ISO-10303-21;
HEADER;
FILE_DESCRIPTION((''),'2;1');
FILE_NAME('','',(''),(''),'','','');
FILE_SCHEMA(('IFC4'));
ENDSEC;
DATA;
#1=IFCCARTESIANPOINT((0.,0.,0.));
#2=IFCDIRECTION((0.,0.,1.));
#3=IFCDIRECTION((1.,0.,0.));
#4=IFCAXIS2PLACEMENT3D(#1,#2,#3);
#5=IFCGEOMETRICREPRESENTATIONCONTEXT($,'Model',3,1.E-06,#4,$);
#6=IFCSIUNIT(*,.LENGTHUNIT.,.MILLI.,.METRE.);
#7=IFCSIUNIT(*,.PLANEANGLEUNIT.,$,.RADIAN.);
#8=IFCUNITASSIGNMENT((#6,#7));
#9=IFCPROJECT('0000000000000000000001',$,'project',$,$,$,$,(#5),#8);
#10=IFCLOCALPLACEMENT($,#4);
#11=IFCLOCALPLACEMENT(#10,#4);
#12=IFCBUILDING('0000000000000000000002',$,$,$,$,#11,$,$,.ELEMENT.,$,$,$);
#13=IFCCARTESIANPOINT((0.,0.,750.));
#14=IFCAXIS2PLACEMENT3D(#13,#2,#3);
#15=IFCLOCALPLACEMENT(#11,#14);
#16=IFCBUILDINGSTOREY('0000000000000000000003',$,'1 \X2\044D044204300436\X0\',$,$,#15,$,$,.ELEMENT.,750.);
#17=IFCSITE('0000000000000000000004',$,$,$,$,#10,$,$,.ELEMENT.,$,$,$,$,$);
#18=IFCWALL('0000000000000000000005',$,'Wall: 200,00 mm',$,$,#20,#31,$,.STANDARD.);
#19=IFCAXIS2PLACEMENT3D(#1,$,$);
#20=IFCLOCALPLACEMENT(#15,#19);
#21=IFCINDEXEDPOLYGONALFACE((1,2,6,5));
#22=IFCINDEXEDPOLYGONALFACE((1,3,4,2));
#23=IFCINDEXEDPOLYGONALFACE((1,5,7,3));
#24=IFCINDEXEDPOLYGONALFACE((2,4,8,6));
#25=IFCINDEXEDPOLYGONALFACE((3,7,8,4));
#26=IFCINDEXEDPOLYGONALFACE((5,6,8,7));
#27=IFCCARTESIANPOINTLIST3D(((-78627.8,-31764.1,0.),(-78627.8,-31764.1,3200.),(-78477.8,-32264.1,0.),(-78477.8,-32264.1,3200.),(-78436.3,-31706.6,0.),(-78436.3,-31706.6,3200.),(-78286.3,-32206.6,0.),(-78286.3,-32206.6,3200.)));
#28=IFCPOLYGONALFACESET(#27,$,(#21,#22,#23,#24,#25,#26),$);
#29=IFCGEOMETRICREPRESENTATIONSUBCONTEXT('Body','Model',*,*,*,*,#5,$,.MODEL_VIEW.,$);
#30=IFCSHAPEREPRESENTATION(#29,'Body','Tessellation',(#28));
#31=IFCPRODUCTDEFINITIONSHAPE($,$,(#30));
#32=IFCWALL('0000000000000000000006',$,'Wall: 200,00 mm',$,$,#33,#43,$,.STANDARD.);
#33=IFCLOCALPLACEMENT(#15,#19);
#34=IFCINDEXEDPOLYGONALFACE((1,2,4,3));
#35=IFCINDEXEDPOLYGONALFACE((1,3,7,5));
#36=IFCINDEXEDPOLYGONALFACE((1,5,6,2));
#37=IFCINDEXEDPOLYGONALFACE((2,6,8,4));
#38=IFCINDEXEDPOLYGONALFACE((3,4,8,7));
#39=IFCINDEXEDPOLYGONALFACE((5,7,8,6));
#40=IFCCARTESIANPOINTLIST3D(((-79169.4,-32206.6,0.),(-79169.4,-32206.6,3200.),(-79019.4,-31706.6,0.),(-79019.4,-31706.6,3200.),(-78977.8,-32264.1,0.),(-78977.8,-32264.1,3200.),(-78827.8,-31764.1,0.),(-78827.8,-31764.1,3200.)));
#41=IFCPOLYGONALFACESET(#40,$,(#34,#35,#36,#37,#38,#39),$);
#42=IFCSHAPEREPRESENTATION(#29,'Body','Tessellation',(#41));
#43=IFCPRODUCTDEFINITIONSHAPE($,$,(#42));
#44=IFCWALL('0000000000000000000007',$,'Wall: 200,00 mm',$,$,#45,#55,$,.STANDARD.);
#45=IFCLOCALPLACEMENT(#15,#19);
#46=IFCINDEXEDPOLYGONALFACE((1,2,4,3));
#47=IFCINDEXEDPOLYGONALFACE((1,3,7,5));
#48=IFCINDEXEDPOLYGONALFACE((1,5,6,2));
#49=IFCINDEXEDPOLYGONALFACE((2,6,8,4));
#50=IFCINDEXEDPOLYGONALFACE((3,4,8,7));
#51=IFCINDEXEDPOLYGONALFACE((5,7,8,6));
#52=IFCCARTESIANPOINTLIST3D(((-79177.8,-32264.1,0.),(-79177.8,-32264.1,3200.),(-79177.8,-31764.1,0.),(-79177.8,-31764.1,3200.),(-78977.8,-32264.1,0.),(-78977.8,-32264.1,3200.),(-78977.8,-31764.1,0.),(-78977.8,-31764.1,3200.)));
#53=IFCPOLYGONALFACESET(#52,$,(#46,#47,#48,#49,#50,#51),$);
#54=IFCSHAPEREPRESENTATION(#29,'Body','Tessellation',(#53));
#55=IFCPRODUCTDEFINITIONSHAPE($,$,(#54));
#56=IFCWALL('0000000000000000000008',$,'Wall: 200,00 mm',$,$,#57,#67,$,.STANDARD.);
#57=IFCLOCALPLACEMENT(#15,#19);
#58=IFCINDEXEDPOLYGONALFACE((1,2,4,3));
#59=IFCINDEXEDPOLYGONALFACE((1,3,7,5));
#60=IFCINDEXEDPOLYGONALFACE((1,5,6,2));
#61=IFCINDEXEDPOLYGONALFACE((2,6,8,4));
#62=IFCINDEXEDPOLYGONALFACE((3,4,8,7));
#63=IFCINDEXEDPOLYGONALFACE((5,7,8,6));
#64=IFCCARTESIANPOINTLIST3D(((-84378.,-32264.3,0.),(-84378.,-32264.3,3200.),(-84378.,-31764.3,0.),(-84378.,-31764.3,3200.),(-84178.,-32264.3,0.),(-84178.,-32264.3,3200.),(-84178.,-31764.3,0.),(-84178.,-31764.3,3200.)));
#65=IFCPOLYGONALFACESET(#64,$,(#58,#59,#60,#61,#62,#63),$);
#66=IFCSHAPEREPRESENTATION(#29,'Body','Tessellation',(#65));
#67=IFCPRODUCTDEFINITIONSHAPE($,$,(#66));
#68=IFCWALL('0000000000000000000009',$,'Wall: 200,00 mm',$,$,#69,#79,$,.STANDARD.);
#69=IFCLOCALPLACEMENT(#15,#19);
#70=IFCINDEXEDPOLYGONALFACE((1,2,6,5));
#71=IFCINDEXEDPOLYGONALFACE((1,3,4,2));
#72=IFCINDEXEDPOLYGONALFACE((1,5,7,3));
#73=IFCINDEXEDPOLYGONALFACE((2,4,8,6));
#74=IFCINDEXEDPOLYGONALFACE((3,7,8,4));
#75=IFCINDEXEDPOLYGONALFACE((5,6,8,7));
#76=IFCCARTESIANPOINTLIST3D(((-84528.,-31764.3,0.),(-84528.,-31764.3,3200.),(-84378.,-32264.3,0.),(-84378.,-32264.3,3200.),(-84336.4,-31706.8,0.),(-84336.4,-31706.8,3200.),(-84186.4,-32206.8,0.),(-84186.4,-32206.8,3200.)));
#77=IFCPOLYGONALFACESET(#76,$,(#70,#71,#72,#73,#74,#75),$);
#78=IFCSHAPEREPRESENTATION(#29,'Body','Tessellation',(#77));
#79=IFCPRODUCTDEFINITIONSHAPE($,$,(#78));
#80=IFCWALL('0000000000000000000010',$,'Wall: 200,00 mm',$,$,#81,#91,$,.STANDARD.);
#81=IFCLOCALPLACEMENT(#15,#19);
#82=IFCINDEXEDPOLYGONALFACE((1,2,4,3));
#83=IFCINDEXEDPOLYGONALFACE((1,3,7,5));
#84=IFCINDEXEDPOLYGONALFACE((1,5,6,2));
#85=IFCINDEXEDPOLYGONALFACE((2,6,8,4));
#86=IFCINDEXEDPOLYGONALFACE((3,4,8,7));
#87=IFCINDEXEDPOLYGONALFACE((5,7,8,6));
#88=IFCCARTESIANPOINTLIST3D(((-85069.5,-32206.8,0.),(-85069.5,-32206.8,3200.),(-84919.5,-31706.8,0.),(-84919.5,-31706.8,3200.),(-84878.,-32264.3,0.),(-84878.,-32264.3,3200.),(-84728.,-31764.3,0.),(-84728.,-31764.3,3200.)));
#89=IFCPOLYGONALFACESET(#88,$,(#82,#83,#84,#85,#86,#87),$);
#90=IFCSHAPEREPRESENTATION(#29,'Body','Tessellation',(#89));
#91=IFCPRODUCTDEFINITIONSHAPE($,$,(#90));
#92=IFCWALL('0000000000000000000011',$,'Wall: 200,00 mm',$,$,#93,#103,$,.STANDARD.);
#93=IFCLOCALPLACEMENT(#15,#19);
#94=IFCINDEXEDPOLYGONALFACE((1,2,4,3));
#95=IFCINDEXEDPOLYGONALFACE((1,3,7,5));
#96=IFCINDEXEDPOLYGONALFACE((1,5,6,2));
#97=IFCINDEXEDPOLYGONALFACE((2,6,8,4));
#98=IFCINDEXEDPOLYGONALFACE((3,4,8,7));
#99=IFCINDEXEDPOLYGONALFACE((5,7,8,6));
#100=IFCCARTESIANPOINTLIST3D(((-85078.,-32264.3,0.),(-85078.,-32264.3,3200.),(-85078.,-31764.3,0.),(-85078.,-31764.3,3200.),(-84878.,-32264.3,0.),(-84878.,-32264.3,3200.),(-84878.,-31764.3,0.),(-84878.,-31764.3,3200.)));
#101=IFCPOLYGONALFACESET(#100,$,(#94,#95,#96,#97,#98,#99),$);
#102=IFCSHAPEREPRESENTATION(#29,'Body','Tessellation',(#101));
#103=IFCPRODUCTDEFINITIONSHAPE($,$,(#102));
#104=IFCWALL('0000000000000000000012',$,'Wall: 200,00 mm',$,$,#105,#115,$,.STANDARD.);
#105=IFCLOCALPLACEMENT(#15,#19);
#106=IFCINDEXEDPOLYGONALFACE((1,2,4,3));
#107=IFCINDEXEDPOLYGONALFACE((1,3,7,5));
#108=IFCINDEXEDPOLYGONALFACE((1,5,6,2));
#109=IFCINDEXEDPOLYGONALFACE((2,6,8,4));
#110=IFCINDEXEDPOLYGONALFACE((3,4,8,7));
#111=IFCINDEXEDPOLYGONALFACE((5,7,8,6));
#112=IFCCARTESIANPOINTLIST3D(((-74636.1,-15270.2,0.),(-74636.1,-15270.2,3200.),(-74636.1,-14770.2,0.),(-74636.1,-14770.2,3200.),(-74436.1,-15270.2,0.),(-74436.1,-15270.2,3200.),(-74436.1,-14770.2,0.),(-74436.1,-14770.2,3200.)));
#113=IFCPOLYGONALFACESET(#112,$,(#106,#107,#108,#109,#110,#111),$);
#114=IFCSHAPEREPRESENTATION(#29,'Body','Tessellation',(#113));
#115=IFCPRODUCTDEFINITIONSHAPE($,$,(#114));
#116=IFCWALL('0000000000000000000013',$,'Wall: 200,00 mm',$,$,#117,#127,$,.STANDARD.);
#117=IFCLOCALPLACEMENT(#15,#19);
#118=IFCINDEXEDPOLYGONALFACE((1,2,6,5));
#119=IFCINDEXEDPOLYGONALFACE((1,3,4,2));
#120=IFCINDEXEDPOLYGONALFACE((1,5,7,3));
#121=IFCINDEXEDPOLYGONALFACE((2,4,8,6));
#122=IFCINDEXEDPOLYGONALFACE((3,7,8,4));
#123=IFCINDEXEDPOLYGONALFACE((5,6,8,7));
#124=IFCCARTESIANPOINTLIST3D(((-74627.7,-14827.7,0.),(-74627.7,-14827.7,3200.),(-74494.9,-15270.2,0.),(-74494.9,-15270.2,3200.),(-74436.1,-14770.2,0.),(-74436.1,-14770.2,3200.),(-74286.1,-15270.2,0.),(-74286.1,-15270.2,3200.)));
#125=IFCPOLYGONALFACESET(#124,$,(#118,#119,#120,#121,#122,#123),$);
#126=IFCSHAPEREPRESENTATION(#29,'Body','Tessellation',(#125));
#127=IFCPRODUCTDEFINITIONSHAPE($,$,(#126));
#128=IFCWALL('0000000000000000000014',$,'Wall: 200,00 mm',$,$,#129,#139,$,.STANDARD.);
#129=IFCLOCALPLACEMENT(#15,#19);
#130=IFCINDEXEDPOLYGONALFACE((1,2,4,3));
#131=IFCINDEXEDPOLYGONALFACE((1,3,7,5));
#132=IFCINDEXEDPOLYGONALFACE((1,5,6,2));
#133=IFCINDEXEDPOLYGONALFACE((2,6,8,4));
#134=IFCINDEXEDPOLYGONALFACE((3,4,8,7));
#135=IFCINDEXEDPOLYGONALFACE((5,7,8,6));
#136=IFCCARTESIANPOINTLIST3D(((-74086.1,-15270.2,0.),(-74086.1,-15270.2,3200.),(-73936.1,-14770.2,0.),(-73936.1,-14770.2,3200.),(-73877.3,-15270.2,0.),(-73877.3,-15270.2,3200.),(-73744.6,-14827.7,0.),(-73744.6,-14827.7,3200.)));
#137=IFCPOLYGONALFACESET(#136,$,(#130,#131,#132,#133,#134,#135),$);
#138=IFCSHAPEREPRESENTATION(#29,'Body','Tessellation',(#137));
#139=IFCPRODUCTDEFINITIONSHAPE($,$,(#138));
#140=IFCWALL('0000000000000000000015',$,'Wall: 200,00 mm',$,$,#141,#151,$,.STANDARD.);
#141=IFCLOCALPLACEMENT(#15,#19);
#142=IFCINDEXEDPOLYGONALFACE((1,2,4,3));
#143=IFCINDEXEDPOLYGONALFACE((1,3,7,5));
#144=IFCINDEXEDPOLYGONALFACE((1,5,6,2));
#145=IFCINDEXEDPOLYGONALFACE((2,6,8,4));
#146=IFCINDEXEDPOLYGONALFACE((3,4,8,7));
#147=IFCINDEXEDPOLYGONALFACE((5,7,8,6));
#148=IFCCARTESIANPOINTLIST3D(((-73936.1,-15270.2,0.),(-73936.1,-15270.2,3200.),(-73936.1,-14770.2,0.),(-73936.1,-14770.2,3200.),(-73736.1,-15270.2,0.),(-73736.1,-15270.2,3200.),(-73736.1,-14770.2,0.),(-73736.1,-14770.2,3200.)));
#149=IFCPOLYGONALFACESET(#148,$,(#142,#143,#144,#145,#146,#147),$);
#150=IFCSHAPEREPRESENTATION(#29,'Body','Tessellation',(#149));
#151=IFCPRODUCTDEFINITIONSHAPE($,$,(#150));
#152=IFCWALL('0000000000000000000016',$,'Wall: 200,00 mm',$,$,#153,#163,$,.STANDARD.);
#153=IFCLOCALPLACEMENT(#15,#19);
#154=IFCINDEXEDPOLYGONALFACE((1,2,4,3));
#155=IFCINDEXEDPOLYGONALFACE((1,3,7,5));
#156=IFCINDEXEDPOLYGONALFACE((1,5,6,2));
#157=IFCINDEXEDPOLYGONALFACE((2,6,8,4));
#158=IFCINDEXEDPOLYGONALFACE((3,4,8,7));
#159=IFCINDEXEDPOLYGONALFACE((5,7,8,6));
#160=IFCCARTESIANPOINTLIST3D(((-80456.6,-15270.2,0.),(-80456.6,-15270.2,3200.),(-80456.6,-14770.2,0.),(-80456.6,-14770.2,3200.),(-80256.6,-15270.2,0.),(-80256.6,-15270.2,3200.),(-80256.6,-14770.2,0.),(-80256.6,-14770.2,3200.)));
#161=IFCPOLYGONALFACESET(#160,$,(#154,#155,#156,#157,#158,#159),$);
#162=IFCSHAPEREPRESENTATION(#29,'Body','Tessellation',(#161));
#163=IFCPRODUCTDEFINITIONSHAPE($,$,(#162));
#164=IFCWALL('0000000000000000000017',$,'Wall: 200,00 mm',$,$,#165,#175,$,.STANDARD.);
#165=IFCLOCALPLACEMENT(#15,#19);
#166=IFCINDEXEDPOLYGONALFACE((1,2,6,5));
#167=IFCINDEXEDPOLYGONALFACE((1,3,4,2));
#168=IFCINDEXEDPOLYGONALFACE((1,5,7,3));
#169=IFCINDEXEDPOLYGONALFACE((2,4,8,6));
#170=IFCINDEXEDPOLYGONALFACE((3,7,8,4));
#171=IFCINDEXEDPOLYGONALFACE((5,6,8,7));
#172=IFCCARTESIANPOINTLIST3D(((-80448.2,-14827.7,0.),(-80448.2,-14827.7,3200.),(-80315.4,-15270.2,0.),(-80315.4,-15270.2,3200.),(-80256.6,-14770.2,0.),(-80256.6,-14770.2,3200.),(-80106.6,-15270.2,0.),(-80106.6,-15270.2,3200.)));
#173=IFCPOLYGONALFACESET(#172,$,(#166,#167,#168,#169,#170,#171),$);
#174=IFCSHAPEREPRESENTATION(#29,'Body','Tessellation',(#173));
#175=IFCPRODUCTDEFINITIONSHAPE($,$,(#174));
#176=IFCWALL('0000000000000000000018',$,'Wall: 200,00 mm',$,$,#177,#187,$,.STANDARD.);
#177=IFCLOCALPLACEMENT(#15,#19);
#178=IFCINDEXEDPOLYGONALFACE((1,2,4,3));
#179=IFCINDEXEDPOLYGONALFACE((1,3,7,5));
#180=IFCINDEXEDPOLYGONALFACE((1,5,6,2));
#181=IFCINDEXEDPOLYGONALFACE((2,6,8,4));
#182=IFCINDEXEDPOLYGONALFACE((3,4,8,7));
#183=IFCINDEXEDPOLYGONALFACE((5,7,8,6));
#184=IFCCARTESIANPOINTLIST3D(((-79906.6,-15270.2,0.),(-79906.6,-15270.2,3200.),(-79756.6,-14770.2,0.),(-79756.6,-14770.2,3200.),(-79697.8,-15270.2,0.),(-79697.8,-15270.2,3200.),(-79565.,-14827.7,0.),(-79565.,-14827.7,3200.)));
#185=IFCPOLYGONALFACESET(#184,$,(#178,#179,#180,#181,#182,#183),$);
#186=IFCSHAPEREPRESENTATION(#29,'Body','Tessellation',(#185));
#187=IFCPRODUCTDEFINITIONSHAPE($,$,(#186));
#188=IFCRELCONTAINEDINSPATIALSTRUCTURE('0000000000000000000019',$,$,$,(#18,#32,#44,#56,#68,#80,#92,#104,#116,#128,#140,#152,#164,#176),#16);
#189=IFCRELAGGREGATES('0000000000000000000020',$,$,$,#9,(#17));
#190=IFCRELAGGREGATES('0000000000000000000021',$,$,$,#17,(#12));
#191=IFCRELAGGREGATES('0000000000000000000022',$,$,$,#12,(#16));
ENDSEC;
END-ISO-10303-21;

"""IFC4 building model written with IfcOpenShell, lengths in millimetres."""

from ifc_helpers import new_model, si_unit, frame, origin_with_axes, place, context, subcontext, project, spatial, line, indexed_curve, outline, extrude, element, save


model = new_model("IFC4")

# Units and contexts
model_context = context("Model", 3, precision=1e-06, world=origin_with_axes())
body_context = subcontext(model_context, "Body", "Model", "MODEL_VIEW")
ifc_project = project(units=[si_unit("LENGTHUNIT", "METRE", prefix="MILLI"), si_unit("PLANEANGLEUNIT", "RADIAN")], contexts=[model_context])

# Site, building, storey
site_placement = place(None, origin_with_axes())
site = spatial("IfcSite", under=ifc_project, at=site_placement, CompositionType="ELEMENT")
building_placement = place(site_placement, origin_with_axes())
building = spatial("IfcBuilding", under=site, at=building_placement, CompositionType="ELEMENT")
storey_placement = place(building_placement, frame((0.0, 0.0, 750.0), z_axis=(0.0, 0.0, 1.0), x_axis=(1.0, 0.0, 0.0)))
storey = spatial("IfcBuildingStorey", under=building, at=storey_placement, Name="1 этаж", CompositionType="ELEMENT", Elevation=750.0)

# Walls
wall_1_placement = place(storey_placement, frame((-78477.8, -32264.1, 0.0), z_axis=(0.0, 0.0, 1.0), x_axis=(-0.287348, 0.957826, 0.0)))
element("IfcWall", 1, at=wall_1_placement, inside=storey, Name="Wall: 200,00 mm", PredefinedType="STANDARD", context=body_context, shape_type="SweptSolid", body=[
    extrude(outline(indexed_curve([(0.0, -200.0), (522.0, -200.0), (522.0, 0.0), (0.0, 0.0)], segments=[line(1, 2), line(2, 3), line(3, 4), line(4, 1)])), origin_with_axes(), (0.0, 0.0, 1.0), 3200.0),
])
wall_2_placement = place(storey_placement, frame((-78977.8, -32264.1, 0.0), z_axis=(0.0, 0.0, 1.0), x_axis=(0.287348, 0.957826, 0.0)))
element("IfcWall", 2, at=wall_2_placement, inside=storey, Name="Wall: 200,00 mm", PredefinedType="STANDARD", context=body_context, shape_type="SweptSolid", body=[
    extrude(outline(indexed_curve([(0.0, 0.0), (522.0, 0.0), (522.0, 200.0), (0.0, 200.0)], segments=[line(1, 2), line(2, 3), line(3, 4), line(4, 1)])), origin_with_axes(), (0.0, 0.0, 1.0), 3200.0),
])
wall_3_placement = place(storey_placement, frame((-79177.8, -32264.1, 0.0), z_axis=(0.0, 0.0, 1.0), x_axis=(0.0, 1.0, 0.0)))
element("IfcWall", 3, at=wall_3_placement, inside=storey, Name="Wall: 200,00 mm", PredefinedType="STANDARD", context=body_context, shape_type="SweptSolid", body=[
    extrude(outline(indexed_curve([(0.0, -200.0), (500.0, -200.0), (500.0, 0.0), (0.0, 0.0)], segments=[line(1, 2), line(2, 3), line(3, 4), line(4, 1)])), origin_with_axes(), (0.0, 0.0, 1.0), 3200.0),
])
wall_4_placement = place(storey_placement, frame((-84178.0, -32264.3, 0.0), z_axis=(0.0, 0.0, 1.0), x_axis=(0.0, 1.0, 0.0)))
element("IfcWall", 4, at=wall_4_placement, inside=storey, Name="Wall: 200,00 mm", PredefinedType="STANDARD", context=body_context, shape_type="SweptSolid", body=[
    extrude(outline(indexed_curve([(0.0, 0.0), (500.0, 0.0), (500.0, 200.0), (0.0, 200.0)], segments=[line(1, 2), line(2, 3), line(3, 4), line(4, 1)])), origin_with_axes(), (0.0, 0.0, 1.0), 3200.0),
])
wall_5_placement = place(storey_placement, frame((-84378.0, -32264.3, 0.0), z_axis=(0.0, 0.0, 1.0), x_axis=(-0.287348, 0.957826, 0.0)))
element("IfcWall", 5, at=wall_5_placement, inside=storey, Name="Wall: 200,00 mm", PredefinedType="STANDARD", context=body_context, shape_type="SweptSolid", body=[
    extrude(outline(indexed_curve([(0.0, -200.0), (522.0, -200.0), (522.0, 0.0), (0.0, 0.0)], segments=[line(1, 2), line(2, 3), line(3, 4), line(4, 1)])), origin_with_axes(), (0.0, 0.0, 1.0), 3200.0),
])
wall_6_placement = place(storey_placement, frame((-84878.0, -32264.3, 0.0), z_axis=(0.0, 0.0, 1.0), x_axis=(0.287348, 0.957826, 0.0)))
element("IfcWall", 6, at=wall_6_placement, inside=storey, Name="Wall: 200,00 mm", PredefinedType="STANDARD", context=body_context, shape_type="SweptSolid", body=[
    extrude(outline(indexed_curve([(0.0, 0.0), (522.0, 0.0), (522.0, 200.0), (0.0, 200.0)], segments=[line(1, 2), line(2, 3), line(3, 4), line(4, 1)])), origin_with_axes(), (0.0, 0.0, 1.0), 3200.0),
])
wall_7_placement = place(storey_placement, frame((-85078.0, -32264.3, 0.0), z_axis=(0.0, 0.0, 1.0), x_axis=(0.0, 1.0, 0.0)))
element("IfcWall", 7, at=wall_7_placement, inside=storey, Name="Wall: 200,00 mm", PredefinedType="STANDARD", context=body_context, shape_type="SweptSolid", body=[
    extrude(outline(indexed_curve([(0.0, -200.0), (500.0, -200.0), (500.0, 0.0), (0.0, 0.0)], segments=[line(1, 2), line(2, 3), line(3, 4), line(4, 1)])), origin_with_axes(), (0.0, 0.0, 1.0), 3200.0),
])
wall_8_placement = place(storey_placement, frame((-74636.1, -14770.2, 0.0), z_axis=(0.0, 0.0, 1.0), x_axis=(0.0, -1.0, 0.0)))
element("IfcWall", 8, at=wall_8_placement, inside=storey, Name="Wall: 200,00 mm", PredefinedType="STANDARD", context=body_context, shape_type="SweptSolid", body=[
    extrude(outline(indexed_curve([(0.0, 0.0), (500.0, 0.0), (500.0, 200.0), (0.0, 200.0)], segments=[line(1, 2), line(2, 3), line(3, 4), line(4, 1)])), origin_with_axes(), (0.0, 0.0, 1.0), 3200.0),
])
wall_9_placement = place(storey_placement, frame((-74436.1, -14770.2, 0.0), z_axis=(0.0, 0.0, 1.0), x_axis=(0.287348, -0.957826, 0.0)))
element("IfcWall", 9, at=wall_9_placement, inside=storey, Name="Wall: 200,00 mm", PredefinedType="STANDARD", context=body_context, shape_type="SweptSolid", body=[
    extrude(outline(indexed_curve([(0.0, -200.0), (462.0, -200.0), (522.0, 0.0), (0.0, 0.0)], segments=[line(1, 2), line(2, 3), line(3, 4), line(4, 1)])), origin_with_axes(), (0.0, 0.0, 1.0), 3200.0),
])
wall_10_placement = place(storey_placement, frame((-73936.1, -14770.2, 0.0), z_axis=(0.0, 0.0, 1.0), x_axis=(-0.287348, -0.957826, 0.0)))
element("IfcWall", 10, at=wall_10_placement, inside=storey, Name="Wall: 200,00 mm", PredefinedType="STANDARD", context=body_context, shape_type="SweptSolid", body=[
    extrude(outline(indexed_curve([(0.0, 0.0), (522.0, 0.0), (462.0, 200.0), (0.0, 200.0)], segments=[line(1, 2), line(2, 3), line(3, 4), line(4, 1)])), origin_with_axes(), (0.0, 0.0, 1.0), 3200.0),
])
wall_11_placement = place(storey_placement, frame((-73736.1, -14770.2, 0.0), z_axis=(0.0, 0.0, 1.0), x_axis=(0.0, -1.0, 0.0)))
element("IfcWall", 11, at=wall_11_placement, inside=storey, Name="Wall: 200,00 mm", PredefinedType="STANDARD", context=body_context, shape_type="SweptSolid", body=[
    extrude(outline(indexed_curve([(0.0, -200.0), (500.0, -200.0), (500.0, 0.0), (0.0, 0.0)], segments=[line(1, 2), line(2, 3), line(3, 4), line(4, 1)])), origin_with_axes(), (0.0, 0.0, 1.0), 3200.0),
])
wall_12_placement = place(storey_placement, frame((-80456.6, -14770.2, 0.0), z_axis=(0.0, 0.0, 1.0), x_axis=(0.0, -1.0, 0.0)))
element("IfcWall", 12, at=wall_12_placement, inside=storey, Name="Wall: 200,00 mm", PredefinedType="STANDARD", context=body_context, shape_type="SweptSolid", body=[
    extrude(outline(indexed_curve([(0.0, 0.0), (500.0, 0.0), (500.0, 200.0), (0.0, 200.0)], segments=[line(1, 2), line(2, 3), line(3, 4), line(4, 1)])), origin_with_axes(), (0.0, 0.0, 1.0), 3200.0),
])
wall_13_placement = place(storey_placement, frame((-80256.6, -14770.2, 0.0), z_axis=(0.0, 0.0, 1.0), x_axis=(0.287348, -0.957826, 0.0)))
element("IfcWall", 13, at=wall_13_placement, inside=storey, Name="Wall: 200,00 mm", PredefinedType="STANDARD", context=body_context, shape_type="SweptSolid", body=[
    extrude(outline(indexed_curve([(0.0, -200.0), (462.0, -200.0), (522.0, 0.0), (0.0, 0.0)], segments=[line(1, 2), line(2, 3), line(3, 4), line(4, 1)])), origin_with_axes(), (0.0, 0.0, 1.0), 3200.0),
])
wall_14_placement = place(storey_placement, frame((-79756.6, -14770.2, 0.0), z_axis=(0.0, 0.0, 1.0), x_axis=(-0.287348, -0.957826, 0.0)))
element("IfcWall", 14, at=wall_14_placement, inside=storey, Name="Wall: 200,00 mm", PredefinedType="STANDARD", context=body_context, shape_type="SweptSolid", body=[
    extrude(outline(indexed_curve([(0.0, 0.0), (522.0, 0.0), (462.0, 200.0), (0.0, 200.0)], segments=[line(1, 2), line(2, 3), line(3, 4), line(4, 1)])), origin_with_axes(), (0.0, 0.0, 1.0), 3200.0),
])

save(model, "model.ifc")
